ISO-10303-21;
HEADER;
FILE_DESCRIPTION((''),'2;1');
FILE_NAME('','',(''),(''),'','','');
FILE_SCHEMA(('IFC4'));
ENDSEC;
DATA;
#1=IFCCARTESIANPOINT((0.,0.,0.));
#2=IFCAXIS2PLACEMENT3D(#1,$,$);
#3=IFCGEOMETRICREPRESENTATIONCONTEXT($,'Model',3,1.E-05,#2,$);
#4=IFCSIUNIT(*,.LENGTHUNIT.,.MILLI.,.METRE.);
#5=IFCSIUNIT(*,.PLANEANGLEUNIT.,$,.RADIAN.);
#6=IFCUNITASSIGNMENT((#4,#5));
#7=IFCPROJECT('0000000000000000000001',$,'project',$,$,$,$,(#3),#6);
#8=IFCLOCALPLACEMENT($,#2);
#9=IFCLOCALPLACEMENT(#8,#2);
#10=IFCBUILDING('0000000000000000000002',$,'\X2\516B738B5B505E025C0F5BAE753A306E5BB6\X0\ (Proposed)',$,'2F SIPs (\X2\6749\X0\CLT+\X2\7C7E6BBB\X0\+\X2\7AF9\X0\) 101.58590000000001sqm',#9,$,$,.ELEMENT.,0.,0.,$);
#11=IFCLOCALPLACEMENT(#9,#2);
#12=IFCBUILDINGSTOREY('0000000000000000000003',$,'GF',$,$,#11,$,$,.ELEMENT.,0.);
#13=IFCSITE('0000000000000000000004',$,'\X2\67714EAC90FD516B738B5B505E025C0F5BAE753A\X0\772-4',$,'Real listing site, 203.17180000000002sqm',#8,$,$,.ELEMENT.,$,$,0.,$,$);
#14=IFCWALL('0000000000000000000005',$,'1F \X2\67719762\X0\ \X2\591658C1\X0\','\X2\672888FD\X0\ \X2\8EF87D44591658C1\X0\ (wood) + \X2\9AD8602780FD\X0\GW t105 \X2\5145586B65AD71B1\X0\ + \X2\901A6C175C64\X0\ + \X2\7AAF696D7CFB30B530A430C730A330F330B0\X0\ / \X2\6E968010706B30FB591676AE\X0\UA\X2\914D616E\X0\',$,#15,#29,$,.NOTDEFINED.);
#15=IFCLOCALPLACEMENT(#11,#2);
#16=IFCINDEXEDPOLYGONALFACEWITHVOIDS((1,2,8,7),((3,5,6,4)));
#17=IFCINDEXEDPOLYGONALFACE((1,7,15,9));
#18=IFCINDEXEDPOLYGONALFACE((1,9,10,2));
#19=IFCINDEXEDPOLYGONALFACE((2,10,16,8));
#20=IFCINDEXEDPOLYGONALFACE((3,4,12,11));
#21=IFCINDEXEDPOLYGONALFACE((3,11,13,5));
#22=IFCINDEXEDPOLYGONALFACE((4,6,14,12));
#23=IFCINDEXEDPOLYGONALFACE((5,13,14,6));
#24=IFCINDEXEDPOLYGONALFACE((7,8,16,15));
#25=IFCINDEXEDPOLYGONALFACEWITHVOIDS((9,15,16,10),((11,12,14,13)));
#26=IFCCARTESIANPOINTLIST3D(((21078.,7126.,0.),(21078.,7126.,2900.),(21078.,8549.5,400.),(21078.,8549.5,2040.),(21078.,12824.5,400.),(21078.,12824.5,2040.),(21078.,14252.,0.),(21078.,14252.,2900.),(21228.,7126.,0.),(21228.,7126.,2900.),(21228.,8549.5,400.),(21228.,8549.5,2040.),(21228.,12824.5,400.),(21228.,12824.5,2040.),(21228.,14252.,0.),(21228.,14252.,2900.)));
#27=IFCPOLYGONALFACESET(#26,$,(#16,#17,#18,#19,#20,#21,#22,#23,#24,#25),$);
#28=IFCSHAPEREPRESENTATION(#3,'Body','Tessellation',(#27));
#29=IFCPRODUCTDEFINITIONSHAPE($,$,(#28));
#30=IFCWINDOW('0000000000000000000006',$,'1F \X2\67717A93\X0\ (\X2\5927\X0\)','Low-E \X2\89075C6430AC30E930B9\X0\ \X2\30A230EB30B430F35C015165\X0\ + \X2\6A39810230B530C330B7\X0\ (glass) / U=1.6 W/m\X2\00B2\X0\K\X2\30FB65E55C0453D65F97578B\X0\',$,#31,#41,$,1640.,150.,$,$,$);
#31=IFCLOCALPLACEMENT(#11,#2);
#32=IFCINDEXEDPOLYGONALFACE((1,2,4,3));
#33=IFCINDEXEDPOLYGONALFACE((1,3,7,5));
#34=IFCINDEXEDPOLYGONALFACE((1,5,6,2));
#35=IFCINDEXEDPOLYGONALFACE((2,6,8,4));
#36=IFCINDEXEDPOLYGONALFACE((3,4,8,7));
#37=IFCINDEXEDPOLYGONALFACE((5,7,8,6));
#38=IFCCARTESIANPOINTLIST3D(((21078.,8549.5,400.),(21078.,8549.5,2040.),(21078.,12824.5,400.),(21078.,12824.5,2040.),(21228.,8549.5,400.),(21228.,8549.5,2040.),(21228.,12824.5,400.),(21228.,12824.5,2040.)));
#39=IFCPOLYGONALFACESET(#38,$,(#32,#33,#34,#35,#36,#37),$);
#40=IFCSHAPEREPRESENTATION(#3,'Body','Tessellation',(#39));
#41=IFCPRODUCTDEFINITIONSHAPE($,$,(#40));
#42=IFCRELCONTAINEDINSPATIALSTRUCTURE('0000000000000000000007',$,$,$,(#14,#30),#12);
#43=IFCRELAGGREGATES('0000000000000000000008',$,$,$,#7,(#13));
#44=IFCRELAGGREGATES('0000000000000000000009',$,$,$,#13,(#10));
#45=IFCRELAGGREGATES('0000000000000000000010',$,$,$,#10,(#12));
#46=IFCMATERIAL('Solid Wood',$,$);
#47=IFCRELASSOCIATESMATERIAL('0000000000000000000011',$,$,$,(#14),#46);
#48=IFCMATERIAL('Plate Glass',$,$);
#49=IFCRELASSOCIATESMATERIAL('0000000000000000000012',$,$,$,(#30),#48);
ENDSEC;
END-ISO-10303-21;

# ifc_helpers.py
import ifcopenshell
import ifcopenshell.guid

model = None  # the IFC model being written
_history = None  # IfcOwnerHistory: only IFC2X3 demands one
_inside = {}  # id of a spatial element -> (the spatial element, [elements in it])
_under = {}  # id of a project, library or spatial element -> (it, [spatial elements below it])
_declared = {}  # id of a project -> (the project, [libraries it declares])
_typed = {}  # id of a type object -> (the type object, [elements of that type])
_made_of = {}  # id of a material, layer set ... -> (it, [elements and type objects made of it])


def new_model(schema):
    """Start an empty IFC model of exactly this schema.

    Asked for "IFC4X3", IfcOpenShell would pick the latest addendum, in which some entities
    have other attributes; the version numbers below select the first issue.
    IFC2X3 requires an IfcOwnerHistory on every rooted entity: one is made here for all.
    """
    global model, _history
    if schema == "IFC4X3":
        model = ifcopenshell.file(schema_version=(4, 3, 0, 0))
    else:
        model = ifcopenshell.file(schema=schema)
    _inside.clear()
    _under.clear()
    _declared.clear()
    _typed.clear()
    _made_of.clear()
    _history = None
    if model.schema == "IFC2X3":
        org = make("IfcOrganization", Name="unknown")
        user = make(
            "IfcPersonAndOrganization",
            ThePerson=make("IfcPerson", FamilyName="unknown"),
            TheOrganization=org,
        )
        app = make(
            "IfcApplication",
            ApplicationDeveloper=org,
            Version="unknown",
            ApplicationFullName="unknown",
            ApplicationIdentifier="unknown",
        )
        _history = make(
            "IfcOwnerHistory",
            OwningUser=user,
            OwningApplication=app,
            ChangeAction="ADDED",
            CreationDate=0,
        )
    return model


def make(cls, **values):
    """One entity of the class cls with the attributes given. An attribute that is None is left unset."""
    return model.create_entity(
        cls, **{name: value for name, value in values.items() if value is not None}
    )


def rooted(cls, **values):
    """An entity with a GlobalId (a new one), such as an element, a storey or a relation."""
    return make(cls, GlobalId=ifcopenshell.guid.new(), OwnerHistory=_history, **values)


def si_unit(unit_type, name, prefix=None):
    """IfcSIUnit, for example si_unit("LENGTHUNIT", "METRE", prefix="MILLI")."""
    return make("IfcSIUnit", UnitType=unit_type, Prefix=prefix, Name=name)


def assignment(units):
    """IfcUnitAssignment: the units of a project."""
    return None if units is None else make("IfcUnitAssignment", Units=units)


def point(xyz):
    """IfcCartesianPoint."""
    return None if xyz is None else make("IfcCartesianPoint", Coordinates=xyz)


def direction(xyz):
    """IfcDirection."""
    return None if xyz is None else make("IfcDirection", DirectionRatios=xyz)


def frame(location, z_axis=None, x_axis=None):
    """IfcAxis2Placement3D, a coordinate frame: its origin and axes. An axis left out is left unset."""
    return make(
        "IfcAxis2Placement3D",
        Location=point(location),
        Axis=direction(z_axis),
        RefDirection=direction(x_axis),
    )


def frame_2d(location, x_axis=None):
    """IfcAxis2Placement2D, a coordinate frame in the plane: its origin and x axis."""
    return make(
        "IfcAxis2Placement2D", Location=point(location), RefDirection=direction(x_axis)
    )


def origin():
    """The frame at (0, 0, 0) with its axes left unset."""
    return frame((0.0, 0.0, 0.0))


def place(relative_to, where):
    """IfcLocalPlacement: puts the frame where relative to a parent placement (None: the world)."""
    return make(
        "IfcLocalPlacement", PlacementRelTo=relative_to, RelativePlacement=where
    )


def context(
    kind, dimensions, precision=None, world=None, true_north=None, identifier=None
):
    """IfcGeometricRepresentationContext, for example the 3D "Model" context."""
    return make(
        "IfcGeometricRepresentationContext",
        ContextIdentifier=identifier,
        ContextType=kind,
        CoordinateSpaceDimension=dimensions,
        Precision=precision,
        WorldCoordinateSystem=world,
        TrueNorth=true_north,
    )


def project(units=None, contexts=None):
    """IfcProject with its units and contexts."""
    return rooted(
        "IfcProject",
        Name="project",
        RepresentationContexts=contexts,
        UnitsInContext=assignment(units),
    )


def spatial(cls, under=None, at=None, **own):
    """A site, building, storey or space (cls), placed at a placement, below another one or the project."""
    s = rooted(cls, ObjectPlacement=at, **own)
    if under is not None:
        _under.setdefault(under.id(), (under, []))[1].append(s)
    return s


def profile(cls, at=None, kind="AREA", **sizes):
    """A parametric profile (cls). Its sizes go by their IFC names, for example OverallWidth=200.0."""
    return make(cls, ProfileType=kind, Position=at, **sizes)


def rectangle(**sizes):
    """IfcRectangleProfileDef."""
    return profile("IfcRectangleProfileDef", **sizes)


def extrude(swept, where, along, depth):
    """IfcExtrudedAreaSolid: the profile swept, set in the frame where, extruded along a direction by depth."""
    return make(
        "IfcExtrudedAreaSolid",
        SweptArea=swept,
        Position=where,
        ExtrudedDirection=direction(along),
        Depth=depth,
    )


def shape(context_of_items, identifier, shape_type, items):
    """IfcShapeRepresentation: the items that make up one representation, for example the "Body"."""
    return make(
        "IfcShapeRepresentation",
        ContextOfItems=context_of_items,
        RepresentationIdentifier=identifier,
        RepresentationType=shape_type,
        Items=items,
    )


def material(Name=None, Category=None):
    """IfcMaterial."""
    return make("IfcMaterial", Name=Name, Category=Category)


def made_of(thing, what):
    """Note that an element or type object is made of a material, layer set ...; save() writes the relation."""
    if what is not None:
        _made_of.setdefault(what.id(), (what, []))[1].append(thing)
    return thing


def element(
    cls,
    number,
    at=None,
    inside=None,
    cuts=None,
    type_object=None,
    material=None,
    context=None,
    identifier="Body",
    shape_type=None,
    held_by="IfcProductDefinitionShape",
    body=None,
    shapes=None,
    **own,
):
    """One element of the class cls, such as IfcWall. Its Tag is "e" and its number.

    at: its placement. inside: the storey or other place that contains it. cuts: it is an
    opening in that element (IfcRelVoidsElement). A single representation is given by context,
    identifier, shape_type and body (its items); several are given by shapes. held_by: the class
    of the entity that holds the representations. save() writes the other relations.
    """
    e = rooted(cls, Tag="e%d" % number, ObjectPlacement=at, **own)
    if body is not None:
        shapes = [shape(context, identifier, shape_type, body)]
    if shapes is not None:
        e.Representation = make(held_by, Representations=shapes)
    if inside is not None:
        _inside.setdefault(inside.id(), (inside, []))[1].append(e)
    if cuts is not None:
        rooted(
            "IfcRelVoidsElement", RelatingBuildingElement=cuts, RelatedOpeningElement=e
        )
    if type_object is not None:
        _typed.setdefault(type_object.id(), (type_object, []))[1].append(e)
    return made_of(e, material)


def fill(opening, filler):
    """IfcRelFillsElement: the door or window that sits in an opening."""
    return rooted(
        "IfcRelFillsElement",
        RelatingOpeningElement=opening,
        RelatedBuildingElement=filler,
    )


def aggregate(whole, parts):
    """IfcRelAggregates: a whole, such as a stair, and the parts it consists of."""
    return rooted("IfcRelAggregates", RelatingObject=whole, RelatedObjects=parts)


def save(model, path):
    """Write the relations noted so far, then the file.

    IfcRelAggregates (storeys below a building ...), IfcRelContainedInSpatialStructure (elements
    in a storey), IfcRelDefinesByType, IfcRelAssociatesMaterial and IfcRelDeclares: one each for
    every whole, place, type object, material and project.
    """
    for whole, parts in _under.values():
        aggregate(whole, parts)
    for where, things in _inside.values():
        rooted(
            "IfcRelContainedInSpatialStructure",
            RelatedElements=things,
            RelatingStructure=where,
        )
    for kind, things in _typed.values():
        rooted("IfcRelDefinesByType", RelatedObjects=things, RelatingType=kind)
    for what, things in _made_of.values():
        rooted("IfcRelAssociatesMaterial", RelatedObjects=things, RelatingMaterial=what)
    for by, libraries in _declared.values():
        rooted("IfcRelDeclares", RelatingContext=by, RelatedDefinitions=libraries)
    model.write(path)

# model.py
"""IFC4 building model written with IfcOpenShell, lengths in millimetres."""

from ifc_helpers import new_model, si_unit, frame, frame_2d, origin, place, context, project, spatial, rectangle, extrude, material, element, fill, save


model = new_model("IFC4")

# Units and contexts
model_context = context("Model", 3, precision=1e-05, world=origin())
ifc_project = project(units=[si_unit("LENGTHUNIT", "METRE", prefix="MILLI"), si_unit("PLANEANGLEUNIT", "RADIAN")], contexts=[model_context])

# Site, building, storey
site_placement = place(None, origin())
site = spatial("IfcSite", under=ifc_project, at=site_placement, Name="東京都八王子市小宮町772-4", ObjectType="Real listing site, 203.17180000000002sqm", CompositionType="ELEMENT", RefElevation=0.0)
building_placement = place(site_placement, origin())
building = spatial("IfcBuilding", under=site, at=building_placement, Name="八王子市小宮町の家 (Proposed)", ObjectType="2F SIPs (杉CLT+籾殻+竹) 101.58590000000001sqm", CompositionType="ELEMENT", ElevationOfRefHeight=0.0, ElevationOfTerrain=0.0)
storey_placement = place(building_placement, origin())
storey = spatial("IfcBuildingStorey", under=building, at=storey_placement, Name="GF", CompositionType="ELEMENT", Elevation=0.0)

# Wall, opening, window
ifc_material_1 = material(Name="Solid Wood")
wall_1_placement = place(storey_placement, frame((10539.0, 3563.0, 0.0)))
wall_1 = element("IfcWall", 1, at=wall_1_placement, inside=storey, material=ifc_material_1, Name="1F 東面 外壁", Description="木製 軸組外壁 (wood) + 高性能GW t105 充填断熱 + 通気層 + 窯業系サイディング / 準耐火・外皮UA配慮", PredefinedType="NOTDEFINED", context=model_context, shape_type="SweptSolid", body=[
    extrude(rectangle(XDim=150.0, YDim=7126.0, at=frame_2d((75.0, 3563.0))), frame((10539.0, 3563.0, 0.0)), (0.0, 0.0, 1.0), 2900.0),
])
opening_1_placement = place(storey_placement, frame((10539.0, 4275.0, 200.0)))
opening_1 = element("IfcOpeningElement", 2, at=opening_1_placement, cuts=wall_1, PredefinedType="NOTDEFINED", context=model_context, shape_type="SweptSolid", body=[
    extrude(rectangle(XDim=150.0, YDim=4275.0, at=frame_2d((75.0, 2137.0))), frame((10539.0, 4275.0, 200.0)), (0.0, 0.0, 1.0), 1640.0),
])
ifc_material_2 = material(Name="Plate Glass")
window_1_placement = place(storey_placement, frame((10539.0, 4275.0, 200.0)))
window_1 = element("IfcWindow", 3, at=window_1_placement, inside=storey, material=ifc_material_2, Name="1F 東窓 (大)", Description="Low-E 複層ガラス アルゴン封入 + 樹脂サッシ (glass) / U=1.6 W/m²K・日射取得型", OverallHeight=1640.0, OverallWidth=150.0, context=model_context, shape_type="SweptSolid", body=[
    extrude(rectangle(XDim=150.0, YDim=4275.0, at=frame_2d((75.0, 2137.0))), frame((10539.0, 4275.0, 200.0)), (0.0, 0.0, 1.0), 1640.0),
])
fill(opening_1, window_1)

save(model, "model.ifc")
